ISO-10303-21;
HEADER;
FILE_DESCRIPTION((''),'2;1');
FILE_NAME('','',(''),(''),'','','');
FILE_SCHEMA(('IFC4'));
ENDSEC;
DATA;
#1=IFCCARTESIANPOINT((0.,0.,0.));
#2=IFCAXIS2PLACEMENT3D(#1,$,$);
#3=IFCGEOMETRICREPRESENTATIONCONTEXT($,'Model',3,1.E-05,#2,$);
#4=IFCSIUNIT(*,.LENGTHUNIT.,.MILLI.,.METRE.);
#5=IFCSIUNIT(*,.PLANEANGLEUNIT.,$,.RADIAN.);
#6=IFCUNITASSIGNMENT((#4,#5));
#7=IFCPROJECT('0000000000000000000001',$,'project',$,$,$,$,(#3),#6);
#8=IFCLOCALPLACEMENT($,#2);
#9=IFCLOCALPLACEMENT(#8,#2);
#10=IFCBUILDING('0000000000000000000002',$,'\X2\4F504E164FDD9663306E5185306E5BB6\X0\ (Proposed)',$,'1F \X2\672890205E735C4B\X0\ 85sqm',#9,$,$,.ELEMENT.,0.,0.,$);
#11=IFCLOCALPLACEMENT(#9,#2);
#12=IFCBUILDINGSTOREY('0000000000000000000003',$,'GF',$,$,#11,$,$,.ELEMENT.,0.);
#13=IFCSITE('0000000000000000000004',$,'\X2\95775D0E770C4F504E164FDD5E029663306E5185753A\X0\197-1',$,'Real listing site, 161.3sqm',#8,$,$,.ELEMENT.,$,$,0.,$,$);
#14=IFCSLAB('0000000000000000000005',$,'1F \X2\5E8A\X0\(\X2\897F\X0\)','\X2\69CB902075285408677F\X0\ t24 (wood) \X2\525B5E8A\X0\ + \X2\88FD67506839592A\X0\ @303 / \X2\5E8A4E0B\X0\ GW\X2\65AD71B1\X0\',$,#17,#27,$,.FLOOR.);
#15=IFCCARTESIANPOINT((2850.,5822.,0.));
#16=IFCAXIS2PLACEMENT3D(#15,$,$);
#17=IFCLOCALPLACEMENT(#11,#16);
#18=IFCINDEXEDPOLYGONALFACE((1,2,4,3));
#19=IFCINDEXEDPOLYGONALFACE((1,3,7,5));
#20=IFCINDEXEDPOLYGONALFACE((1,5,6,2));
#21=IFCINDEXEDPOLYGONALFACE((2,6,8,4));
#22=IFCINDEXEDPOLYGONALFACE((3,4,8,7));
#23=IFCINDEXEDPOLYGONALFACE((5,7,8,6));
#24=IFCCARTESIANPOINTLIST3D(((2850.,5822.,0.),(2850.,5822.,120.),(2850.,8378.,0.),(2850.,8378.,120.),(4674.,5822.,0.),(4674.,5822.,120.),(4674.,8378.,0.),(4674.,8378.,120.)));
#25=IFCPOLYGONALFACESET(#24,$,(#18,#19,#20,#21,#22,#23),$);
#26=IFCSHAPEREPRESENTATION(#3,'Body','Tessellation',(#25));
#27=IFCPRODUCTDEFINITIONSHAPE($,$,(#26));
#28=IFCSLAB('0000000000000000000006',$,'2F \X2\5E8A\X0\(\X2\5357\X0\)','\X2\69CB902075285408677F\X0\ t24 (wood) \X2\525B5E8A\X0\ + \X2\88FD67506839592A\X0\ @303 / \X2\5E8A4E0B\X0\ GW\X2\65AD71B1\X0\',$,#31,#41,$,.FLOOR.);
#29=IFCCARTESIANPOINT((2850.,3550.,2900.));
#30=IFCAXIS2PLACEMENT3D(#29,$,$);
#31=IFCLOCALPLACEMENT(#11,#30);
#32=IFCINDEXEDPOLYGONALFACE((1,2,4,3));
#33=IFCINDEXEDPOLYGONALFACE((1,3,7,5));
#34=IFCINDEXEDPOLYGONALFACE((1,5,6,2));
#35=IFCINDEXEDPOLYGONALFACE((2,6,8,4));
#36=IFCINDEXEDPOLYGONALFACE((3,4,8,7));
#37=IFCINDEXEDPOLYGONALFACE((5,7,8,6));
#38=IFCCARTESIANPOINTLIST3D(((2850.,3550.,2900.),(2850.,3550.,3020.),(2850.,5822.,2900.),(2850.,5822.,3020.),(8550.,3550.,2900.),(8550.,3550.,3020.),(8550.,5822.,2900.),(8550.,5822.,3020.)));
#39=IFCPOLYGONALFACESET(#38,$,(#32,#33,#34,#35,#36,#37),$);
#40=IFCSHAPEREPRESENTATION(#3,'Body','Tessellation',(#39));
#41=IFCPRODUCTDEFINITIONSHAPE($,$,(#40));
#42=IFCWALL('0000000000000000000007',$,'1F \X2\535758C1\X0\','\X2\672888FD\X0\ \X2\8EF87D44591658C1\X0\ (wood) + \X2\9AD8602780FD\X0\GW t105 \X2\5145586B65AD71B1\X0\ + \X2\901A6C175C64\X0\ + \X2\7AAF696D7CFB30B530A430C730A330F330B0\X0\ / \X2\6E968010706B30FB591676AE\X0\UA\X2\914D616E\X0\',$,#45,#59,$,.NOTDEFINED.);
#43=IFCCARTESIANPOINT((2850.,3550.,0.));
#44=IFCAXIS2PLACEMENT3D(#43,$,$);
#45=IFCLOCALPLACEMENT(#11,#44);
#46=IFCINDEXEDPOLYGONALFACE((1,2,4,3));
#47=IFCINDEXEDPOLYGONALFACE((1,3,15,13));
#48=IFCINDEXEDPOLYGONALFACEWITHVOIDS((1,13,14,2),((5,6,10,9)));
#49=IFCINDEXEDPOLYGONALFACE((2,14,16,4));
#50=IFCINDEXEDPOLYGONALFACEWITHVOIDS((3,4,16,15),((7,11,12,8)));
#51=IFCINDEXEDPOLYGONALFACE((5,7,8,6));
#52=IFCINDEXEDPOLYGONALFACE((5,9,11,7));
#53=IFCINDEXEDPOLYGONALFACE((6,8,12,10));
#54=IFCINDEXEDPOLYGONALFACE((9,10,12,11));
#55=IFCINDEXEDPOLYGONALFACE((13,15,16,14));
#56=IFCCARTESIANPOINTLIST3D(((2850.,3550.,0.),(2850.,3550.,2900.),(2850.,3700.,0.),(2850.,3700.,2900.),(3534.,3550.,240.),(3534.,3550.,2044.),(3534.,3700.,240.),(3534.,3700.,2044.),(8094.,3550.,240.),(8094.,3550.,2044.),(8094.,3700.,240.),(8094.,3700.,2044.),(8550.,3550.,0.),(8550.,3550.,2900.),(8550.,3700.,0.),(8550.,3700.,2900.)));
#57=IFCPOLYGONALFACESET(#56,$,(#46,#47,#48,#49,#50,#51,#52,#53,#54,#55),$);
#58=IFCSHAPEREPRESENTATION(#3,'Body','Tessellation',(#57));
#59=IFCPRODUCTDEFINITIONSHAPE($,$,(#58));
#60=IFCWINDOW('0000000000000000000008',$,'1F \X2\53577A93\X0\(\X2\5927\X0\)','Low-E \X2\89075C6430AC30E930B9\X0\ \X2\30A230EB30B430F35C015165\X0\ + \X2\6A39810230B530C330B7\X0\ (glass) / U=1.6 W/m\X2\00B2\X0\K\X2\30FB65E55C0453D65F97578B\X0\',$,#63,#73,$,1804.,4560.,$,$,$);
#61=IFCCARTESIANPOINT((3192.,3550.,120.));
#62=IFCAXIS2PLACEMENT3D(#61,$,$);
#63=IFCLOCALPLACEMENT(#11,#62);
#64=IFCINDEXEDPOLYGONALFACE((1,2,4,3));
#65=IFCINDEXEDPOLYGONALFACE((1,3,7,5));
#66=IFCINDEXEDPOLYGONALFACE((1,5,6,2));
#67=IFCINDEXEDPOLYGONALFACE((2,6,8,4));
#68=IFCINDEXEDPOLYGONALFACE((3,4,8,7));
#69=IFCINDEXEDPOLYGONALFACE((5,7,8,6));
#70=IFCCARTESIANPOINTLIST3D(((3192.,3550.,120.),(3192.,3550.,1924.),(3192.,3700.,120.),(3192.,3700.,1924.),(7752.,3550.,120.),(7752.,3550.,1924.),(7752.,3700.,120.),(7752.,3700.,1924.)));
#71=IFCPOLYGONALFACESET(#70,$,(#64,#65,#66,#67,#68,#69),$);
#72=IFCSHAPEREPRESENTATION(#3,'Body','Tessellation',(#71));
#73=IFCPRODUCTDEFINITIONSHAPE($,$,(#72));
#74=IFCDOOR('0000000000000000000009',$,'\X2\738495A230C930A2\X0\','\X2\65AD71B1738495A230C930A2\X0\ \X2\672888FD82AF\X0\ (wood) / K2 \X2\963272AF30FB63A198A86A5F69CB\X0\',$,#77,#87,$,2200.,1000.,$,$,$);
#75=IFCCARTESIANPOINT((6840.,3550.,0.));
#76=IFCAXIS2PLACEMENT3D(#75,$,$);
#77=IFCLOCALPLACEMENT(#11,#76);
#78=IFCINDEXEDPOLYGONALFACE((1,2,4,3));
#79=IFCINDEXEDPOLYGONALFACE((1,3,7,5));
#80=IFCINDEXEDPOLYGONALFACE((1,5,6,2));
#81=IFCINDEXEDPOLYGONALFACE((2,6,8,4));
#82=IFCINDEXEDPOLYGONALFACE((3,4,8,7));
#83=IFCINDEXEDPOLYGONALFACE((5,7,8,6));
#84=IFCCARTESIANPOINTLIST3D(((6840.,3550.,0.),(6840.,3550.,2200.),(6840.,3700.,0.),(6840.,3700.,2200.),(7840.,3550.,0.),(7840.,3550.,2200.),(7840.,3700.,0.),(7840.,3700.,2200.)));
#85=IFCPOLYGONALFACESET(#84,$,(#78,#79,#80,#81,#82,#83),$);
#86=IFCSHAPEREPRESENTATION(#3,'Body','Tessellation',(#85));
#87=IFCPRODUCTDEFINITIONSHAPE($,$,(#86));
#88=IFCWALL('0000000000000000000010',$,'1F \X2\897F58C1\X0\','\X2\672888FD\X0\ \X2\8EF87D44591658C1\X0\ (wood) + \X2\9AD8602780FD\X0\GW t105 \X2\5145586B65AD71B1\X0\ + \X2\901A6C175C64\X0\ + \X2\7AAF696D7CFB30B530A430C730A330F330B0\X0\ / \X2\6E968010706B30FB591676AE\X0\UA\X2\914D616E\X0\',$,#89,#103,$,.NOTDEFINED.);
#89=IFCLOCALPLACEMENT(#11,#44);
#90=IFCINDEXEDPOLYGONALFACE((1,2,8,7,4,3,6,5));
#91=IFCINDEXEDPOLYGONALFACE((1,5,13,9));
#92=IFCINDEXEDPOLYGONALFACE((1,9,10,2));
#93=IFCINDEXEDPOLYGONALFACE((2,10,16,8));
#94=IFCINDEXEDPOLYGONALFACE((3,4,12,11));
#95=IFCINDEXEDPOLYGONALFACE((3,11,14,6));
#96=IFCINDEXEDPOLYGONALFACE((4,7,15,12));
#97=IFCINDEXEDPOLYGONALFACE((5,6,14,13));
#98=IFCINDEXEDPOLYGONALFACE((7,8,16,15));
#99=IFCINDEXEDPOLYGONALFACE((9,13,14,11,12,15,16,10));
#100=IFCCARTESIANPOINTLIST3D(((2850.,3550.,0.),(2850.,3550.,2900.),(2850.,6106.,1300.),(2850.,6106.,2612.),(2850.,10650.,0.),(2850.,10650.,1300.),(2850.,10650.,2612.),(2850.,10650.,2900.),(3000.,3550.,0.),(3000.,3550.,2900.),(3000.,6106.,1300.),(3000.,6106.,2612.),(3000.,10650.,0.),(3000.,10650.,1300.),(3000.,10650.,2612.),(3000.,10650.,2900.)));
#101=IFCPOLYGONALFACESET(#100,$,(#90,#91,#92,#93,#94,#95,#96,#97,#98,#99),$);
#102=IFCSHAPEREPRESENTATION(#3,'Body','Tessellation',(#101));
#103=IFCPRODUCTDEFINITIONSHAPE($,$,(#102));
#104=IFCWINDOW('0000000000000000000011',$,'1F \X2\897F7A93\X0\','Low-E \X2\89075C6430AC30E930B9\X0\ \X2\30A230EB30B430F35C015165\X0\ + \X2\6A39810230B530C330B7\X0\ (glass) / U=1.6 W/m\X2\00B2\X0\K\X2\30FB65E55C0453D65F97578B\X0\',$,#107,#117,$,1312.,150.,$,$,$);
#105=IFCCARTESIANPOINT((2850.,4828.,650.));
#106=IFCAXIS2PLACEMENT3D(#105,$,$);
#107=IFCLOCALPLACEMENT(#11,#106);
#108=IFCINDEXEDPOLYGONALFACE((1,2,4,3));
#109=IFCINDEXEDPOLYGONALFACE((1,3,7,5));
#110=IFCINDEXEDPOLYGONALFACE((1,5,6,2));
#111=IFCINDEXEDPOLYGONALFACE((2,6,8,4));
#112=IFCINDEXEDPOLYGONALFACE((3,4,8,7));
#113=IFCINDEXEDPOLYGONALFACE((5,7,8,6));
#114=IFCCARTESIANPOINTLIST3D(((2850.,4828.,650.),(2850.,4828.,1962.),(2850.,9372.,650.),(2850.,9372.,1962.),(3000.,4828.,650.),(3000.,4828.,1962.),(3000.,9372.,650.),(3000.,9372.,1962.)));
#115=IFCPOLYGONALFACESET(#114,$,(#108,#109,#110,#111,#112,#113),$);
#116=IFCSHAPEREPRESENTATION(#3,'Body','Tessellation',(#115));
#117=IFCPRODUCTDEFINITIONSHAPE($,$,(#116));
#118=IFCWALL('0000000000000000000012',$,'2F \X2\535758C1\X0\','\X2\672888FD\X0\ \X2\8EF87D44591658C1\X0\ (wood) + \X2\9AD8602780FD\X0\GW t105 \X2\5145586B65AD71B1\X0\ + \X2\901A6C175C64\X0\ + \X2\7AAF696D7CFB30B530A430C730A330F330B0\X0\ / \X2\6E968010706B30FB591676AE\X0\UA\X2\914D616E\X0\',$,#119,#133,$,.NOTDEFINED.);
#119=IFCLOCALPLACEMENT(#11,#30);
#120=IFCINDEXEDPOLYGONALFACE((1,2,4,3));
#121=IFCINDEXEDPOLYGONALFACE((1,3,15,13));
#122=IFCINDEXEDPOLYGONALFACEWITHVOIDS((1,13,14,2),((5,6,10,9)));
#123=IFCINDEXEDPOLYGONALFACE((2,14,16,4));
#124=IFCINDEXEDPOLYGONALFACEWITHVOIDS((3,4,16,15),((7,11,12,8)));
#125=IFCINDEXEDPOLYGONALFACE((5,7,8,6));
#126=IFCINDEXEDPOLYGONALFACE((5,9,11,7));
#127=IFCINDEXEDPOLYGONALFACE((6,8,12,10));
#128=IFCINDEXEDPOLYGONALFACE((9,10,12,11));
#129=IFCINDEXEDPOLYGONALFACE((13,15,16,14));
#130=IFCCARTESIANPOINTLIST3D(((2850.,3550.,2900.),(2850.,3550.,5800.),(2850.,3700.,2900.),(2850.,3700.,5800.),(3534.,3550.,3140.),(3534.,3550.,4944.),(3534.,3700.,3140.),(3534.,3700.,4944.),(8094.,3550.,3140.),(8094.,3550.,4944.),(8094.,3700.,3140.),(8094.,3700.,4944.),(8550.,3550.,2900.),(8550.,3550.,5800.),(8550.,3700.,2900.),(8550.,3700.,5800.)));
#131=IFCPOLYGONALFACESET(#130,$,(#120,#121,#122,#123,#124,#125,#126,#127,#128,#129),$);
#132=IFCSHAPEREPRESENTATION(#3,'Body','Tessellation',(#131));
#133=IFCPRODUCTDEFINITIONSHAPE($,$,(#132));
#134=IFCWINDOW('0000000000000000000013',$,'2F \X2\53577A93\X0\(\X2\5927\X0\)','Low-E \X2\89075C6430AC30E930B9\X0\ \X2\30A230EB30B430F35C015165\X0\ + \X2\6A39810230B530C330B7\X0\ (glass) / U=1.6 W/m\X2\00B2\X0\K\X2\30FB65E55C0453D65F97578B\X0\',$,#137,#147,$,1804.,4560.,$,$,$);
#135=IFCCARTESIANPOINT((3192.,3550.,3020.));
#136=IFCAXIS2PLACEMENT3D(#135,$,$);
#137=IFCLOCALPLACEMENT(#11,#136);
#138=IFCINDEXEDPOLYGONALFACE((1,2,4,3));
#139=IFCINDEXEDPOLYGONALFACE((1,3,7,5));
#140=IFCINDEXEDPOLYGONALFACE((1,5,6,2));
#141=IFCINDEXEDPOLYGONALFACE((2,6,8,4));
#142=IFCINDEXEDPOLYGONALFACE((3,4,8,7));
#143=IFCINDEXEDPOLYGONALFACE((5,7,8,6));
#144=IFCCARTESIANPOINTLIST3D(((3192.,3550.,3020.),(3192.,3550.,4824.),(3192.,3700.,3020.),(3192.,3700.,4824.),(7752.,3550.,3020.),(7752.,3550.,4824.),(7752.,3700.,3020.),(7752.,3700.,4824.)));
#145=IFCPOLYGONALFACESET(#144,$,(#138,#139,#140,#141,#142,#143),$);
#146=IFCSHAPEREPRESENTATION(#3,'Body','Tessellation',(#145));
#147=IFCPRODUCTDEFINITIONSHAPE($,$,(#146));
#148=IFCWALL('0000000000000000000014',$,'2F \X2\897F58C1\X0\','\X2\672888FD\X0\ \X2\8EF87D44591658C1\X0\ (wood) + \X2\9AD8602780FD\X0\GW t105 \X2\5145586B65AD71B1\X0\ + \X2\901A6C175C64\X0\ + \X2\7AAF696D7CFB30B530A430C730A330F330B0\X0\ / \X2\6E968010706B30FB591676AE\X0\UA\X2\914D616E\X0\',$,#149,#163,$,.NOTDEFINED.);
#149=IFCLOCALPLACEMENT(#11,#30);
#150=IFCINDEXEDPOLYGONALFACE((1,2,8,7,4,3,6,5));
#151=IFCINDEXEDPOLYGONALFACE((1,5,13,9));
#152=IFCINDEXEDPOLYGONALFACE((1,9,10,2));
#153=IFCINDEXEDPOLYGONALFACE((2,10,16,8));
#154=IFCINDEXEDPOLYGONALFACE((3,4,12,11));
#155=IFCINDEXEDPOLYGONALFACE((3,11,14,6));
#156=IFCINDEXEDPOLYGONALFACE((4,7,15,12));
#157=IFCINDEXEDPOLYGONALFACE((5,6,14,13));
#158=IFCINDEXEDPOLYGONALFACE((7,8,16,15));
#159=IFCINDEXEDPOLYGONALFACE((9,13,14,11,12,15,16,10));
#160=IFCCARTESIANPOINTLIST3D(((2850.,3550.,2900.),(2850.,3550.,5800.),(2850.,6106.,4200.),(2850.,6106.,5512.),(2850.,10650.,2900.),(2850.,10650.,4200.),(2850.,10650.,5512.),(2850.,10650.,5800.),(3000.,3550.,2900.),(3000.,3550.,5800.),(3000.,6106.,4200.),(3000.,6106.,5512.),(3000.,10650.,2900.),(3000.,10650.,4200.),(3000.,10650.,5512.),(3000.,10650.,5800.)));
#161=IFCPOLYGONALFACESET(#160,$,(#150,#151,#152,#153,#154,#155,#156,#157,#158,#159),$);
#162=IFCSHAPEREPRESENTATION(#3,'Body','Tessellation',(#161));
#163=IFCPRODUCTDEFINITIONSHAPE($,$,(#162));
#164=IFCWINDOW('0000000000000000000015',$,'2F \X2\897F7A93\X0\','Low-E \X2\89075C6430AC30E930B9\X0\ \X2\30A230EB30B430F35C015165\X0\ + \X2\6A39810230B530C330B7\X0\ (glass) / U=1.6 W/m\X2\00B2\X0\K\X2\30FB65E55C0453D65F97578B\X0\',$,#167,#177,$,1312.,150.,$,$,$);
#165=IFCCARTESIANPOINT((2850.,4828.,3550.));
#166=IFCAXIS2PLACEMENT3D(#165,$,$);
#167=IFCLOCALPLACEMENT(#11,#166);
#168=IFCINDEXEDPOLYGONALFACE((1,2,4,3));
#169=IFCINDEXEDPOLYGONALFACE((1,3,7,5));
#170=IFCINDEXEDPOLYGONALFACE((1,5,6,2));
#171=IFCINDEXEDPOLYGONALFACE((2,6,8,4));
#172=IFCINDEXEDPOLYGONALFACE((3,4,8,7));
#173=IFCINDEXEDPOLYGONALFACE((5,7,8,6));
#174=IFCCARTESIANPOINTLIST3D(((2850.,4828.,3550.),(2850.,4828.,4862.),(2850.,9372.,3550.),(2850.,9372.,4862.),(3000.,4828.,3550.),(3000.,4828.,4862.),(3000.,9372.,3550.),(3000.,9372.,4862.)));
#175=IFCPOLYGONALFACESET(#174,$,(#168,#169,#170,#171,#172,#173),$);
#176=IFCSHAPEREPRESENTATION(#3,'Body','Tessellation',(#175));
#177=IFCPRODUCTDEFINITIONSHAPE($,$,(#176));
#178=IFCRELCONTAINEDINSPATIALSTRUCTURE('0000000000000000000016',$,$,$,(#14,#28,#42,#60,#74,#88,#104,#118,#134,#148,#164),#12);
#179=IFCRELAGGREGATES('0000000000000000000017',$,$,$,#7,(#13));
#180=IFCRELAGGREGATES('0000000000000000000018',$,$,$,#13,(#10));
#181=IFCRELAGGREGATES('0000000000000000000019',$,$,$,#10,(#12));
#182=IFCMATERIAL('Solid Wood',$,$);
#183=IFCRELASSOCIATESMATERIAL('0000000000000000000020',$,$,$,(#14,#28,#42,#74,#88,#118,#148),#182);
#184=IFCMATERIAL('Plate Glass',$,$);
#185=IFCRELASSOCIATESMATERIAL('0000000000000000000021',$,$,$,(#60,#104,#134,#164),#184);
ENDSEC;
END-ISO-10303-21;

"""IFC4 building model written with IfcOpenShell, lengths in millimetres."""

from ifc_helpers import new_model, si_unit, frame, frame_2d, origin, place, context, project, spatial, rectangle, extrude, material, element, fill, save


model = new_model("IFC4")

# Units and contexts
model_context = context("Model", 3, precision=1e-05, world=origin())
ifc_project = project(units=[si_unit("LENGTHUNIT", "METRE", prefix="MILLI"), si_unit("PLANEANGLEUNIT", "RADIAN")], contexts=[model_context])

# Site, building, storey
site_placement = place(None, origin())
site = spatial("IfcSite", under=ifc_project, at=site_placement, Name="長崎県佐世保市陣の内町197-1", ObjectType="Real listing site, 161.3sqm", CompositionType="ELEMENT", RefElevation=0.0)
building_placement = place(site_placement, origin())
building = spatial("IfcBuilding", under=site, at=building_placement, Name="佐世保陣の内の家 (Proposed)", ObjectType="1F 木造平屋 85sqm", CompositionType="ELEMENT", ElevationOfRefHeight=0.0, ElevationOfTerrain=0.0)
storey_placement = place(building_placement, origin())
storey = spatial("IfcBuildingStorey", under=building, at=storey_placement, Name="GF", CompositionType="ELEMENT", Elevation=0.0)

# Slabs
ifc_material_1 = material(Name="Solid Wood")
slab_1_placement = place(storey_placement, frame((2850.0, 5822.0, 0.0)))
element("IfcSlab", 1, at=slab_1_placement, inside=storey, material=ifc_material_1, Name="1F 床(西)", Description="構造用合板 t24 (wood) 剛床 + 製材根太 @303 / 床下 GW断熱", PredefinedType="FLOOR", context=model_context, shape_type="SweptSolid", body=[
    extrude(rectangle(XDim=1824.0, YDim=2556.0, at=frame_2d((912.0, 1278.0))), frame((2850.0, 5822.0, 0.0)), (0.0, 0.0, 1.0), 120.0),
])
slab_2_placement = place(storey_placement, frame((2850.0, 3550.0, 2900.0)))
element("IfcSlab", 2, at=slab_2_placement, inside=storey, material=ifc_material_1, Name="2F 床(南)", Description="構造用合板 t24 (wood) 剛床 + 製材根太 @303 / 床下 GW断熱", PredefinedType="FLOOR", context=model_context, shape_type="SweptSolid", body=[
    extrude(rectangle(XDim=5700.0, YDim=2272.0, at=frame_2d((2850.0, 1136.0))), frame((2850.0, 3550.0, 2900.0)), (0.0, 0.0, 1.0), 120.0),
])

# Wall, openings, window, door
wall_1_placement = place(storey_placement, frame((2850.0, 3550.0, 0.0)))
wall_1 = element("IfcWall", 3, at=wall_1_placement, inside=storey, material=ifc_material_1, Name="1F 南壁", Description="木製 軸組外壁 (wood) + 高性能GW t105 充填断熱 + 通気層 + 窯業系サイディング / 準耐火・外皮UA配慮", PredefinedType="NOTDEFINED", context=model_context, shape_type="SweptSolid", body=[
    extrude(rectangle(XDim=5700.0, YDim=150.0, at=frame_2d((2850.0, 75.0))), frame((2850.0, 3550.0, 0.0)), (0.0, 0.0, 1.0), 2900.0),
])
opening_1_placement = place(storey_placement, frame((3192.0, 3550.0, 120.0)))
opening_1 = element("IfcOpeningElement", 4, at=opening_1_placement, cuts=wall_1, PredefinedType="NOTDEFINED", context=model_context, shape_type="SweptSolid", body=[
    extrude(rectangle(XDim=4560.0, YDim=150.0, at=frame_2d((2280.0, 75.0))), frame((3192.0, 3550.0, 120.0)), (0.0, 0.0, 1.0), 1804.0),
])
opening_2_placement = place(storey_placement, frame((6840.0, 3550.0, 0.0)))
opening_2 = element("IfcOpeningElement", 5, at=opening_2_placement, cuts=wall_1, PredefinedType="NOTDEFINED", context=model_context, shape_type="SweptSolid", body=[
    extrude(rectangle(XDim=1000.0, YDim=150.0, at=frame_2d((500.0, 75.0))), frame((6840.0, 3550.0, 0.0)), (0.0, 0.0, 1.0), 2200.0),
])
ifc_material_2 = material(Name="Plate Glass")
window_1_placement = place(storey_placement, frame((3192.0, 3550.0, 120.0)))
window_1 = element("IfcWindow", 6, at=window_1_placement, inside=storey, material=ifc_material_2, Name="1F 南窓(大)", Description="Low-E 複層ガラス アルゴン封入 + 樹脂サッシ (glass) / U=1.6 W/m²K・日射取得型", OverallHeight=1804.0, OverallWidth=4560.0, context=model_context, shape_type="SweptSolid", body=[
    extrude(rectangle(XDim=4560.0, YDim=150.0, at=frame_2d((2280.0, 75.0))), frame((3192.0, 3550.0, 120.0)), (0.0, 0.0, 1.0), 1804.0),
])
fill(opening_1, window_1)
door_placement = place(storey_placement, frame((6840.0, 3550.0, 0.0)))
door = element("IfcDoor", 7, at=door_placement, inside=storey, material=ifc_material_1, Name="玄関ドア", Description="断熱玄関ドア 木製芯 (wood) / K2 防犯・採風機構", OverallHeight=2200.0, OverallWidth=1000.0, context=model_context, shape_type="SweptSolid", body=[
    extrude(rectangle(XDim=1000.0, YDim=150.0, at=frame_2d((500.0, 75.0))), frame((6840.0, 3550.0, 0.0)), (0.0, 0.0, 1.0), 2200.0),
])
fill(opening_2, door)

# Walls, openings, windows
wall_2_placement = place(storey_placement, frame((2850.0, 3550.0, 0.0)))
wall_2 = element("IfcWall", 8, at=wall_2_placement, inside=storey, material=ifc_material_1, Name="1F 西壁", Description="木製 軸組外壁 (wood) + 高性能GW t105 充填断熱 + 通気層 + 窯業系サイディング / 準耐火・外皮UA配慮", PredefinedType="NOTDEFINED", context=model_context, shape_type="SweptSolid", body=[
    extrude(rectangle(XDim=150.0, YDim=7100.0, at=frame_2d((75.0, 3550.0))), frame((2850.0, 3550.0, 0.0)), (0.0, 0.0, 1.0), 2900.0),
])
opening_3_placement = place(storey_placement, frame((2850.0, 4828.0, 650.0)))
opening_3 = element("IfcOpeningElement", 9, at=opening_3_placement, cuts=wall_2, PredefinedType="NOTDEFINED", context=model_context, shape_type="SweptSolid", body=[
    extrude(rectangle(XDim=150.0, YDim=4544.0, at=frame_2d((75.0, 2272.0))), frame((2850.0, 4828.0, 650.0)), (0.0, 0.0, 1.0), 1312.0),
])
window_2_placement = place(storey_placement, frame((2850.0, 4828.0, 650.0)))
window_2 = element("IfcWindow", 10, at=window_2_placement, inside=storey, material=ifc_material_2, Name="1F 西窓", Description="Low-E 複層ガラス アルゴン封入 + 樹脂サッシ (glass) / U=1.6 W/m²K・日射取得型", OverallHeight=1312.0, OverallWidth=150.0, context=model_context, shape_type="SweptSolid", body=[
    extrude(rectangle(XDim=150.0, YDim=4544.0, at=frame_2d((75.0, 2272.0))), frame((2850.0, 4828.0, 650.0)), (0.0, 0.0, 1.0), 1312.0),
])
fill(opening_3, window_2)
wall_3_placement = place(storey_placement, frame((2850.0, 3550.0, 2900.0)))
wall_3 = element("IfcWall", 11, at=wall_3_placement, inside=storey, material=ifc_material_1, Name="2F 南壁", Description="木製 軸組外壁 (wood) + 高性能GW t105 充填断熱 + 通気層 + 窯業系サイディング / 準耐火・外皮UA配慮", PredefinedType="NOTDEFINED", context=model_context, shape_type="SweptSolid", body=[
    extrude(rectangle(XDim=5700.0, YDim=150.0, at=frame_2d((2850.0, 75.0))), frame((2850.0, 3550.0, 2900.0)), (0.0, 0.0, 1.0), 2900.0),
])
opening_4_placement = place(storey_placement, frame((3192.0, 3550.0, 3020.0)))
opening_4 = element("IfcOpeningElement", 12, at=opening_4_placement, cuts=wall_3, PredefinedType="NOTDEFINED", context=model_context, shape_type="SweptSolid", body=[
    extrude(rectangle(XDim=4560.0, YDim=150.0, at=frame_2d((2280.0, 75.0))), frame((3192.0, 3550.0, 3020.0)), (0.0, 0.0, 1.0), 1804.0),
])
window_3_placement = place(storey_placement, frame((3192.0, 3550.0, 3020.0)))
window_3 = element("IfcWindow", 13, at=window_3_placement, inside=storey, material=ifc_material_2, Name="2F 南窓(大)", Description="Low-E 複層ガラス アルゴン封入 + 樹脂サッシ (glass) / U=1.6 W/m²K・日射取得型", OverallHeight=1804.0, OverallWidth=4560.0, context=model_context, shape_type="SweptSolid", body=[
    extrude(rectangle(XDim=4560.0, YDim=150.0, at=frame_2d((2280.0, 75.0))), frame((3192.0, 3550.0, 3020.0)), (0.0, 0.0, 1.0), 1804.0),
])
fill(opening_4, window_3)
wall_4_placement = place(storey_placement, frame((2850.0, 3550.0, 2900.0)))
wall_4 = element("IfcWall", 14, at=wall_4_placement, inside=storey, material=ifc_material_1, Name="2F 西壁", Description="木製 軸組外壁 (wood) + 高性能GW t105 充填断熱 + 通気層 + 窯業系サイディング / 準耐火・外皮UA配慮", PredefinedType="NOTDEFINED", context=model_context, shape_type="SweptSolid", body=[
    extrude(rectangle(XDim=150.0, YDim=7100.0, at=frame_2d((75.0, 3550.0))), frame((2850.0, 3550.0, 2900.0)), (0.0, 0.0, 1.0), 2900.0),
])
opening_5_placement = place(storey_placement, frame((2850.0, 4828.0, 3550.0)))
opening_5 = element("IfcOpeningElement", 15, at=opening_5_placement, cuts=wall_4, PredefinedType="NOTDEFINED", context=model_context, shape_type="SweptSolid", body=[
    extrude(rectangle(XDim=150.0, YDim=4544.0, at=frame_2d((75.0, 2272.0))), frame((2850.0, 4828.0, 3550.0)), (0.0, 0.0, 1.0), 1312.0),
])
window_4_placement = place(storey_placement, frame((2850.0, 4828.0, 3550.0)))
window_4 = element("IfcWindow", 16, at=window_4_placement, inside=storey, material=ifc_material_2, Name="2F 西窓", Description="Low-E 複層ガラス アルゴン封入 + 樹脂サッシ (glass) / U=1.6 W/m²K・日射取得型", OverallHeight=1312.0, OverallWidth=150.0, context=model_context, shape_type="SweptSolid", body=[
    extrude(rectangle(XDim=150.0, YDim=4544.0, at=frame_2d((75.0, 2272.0))), frame((2850.0, 4828.0, 3550.0)), (0.0, 0.0, 1.0), 1312.0),
])
fill(opening_5, window_4)

save(model, "model.ifc")
